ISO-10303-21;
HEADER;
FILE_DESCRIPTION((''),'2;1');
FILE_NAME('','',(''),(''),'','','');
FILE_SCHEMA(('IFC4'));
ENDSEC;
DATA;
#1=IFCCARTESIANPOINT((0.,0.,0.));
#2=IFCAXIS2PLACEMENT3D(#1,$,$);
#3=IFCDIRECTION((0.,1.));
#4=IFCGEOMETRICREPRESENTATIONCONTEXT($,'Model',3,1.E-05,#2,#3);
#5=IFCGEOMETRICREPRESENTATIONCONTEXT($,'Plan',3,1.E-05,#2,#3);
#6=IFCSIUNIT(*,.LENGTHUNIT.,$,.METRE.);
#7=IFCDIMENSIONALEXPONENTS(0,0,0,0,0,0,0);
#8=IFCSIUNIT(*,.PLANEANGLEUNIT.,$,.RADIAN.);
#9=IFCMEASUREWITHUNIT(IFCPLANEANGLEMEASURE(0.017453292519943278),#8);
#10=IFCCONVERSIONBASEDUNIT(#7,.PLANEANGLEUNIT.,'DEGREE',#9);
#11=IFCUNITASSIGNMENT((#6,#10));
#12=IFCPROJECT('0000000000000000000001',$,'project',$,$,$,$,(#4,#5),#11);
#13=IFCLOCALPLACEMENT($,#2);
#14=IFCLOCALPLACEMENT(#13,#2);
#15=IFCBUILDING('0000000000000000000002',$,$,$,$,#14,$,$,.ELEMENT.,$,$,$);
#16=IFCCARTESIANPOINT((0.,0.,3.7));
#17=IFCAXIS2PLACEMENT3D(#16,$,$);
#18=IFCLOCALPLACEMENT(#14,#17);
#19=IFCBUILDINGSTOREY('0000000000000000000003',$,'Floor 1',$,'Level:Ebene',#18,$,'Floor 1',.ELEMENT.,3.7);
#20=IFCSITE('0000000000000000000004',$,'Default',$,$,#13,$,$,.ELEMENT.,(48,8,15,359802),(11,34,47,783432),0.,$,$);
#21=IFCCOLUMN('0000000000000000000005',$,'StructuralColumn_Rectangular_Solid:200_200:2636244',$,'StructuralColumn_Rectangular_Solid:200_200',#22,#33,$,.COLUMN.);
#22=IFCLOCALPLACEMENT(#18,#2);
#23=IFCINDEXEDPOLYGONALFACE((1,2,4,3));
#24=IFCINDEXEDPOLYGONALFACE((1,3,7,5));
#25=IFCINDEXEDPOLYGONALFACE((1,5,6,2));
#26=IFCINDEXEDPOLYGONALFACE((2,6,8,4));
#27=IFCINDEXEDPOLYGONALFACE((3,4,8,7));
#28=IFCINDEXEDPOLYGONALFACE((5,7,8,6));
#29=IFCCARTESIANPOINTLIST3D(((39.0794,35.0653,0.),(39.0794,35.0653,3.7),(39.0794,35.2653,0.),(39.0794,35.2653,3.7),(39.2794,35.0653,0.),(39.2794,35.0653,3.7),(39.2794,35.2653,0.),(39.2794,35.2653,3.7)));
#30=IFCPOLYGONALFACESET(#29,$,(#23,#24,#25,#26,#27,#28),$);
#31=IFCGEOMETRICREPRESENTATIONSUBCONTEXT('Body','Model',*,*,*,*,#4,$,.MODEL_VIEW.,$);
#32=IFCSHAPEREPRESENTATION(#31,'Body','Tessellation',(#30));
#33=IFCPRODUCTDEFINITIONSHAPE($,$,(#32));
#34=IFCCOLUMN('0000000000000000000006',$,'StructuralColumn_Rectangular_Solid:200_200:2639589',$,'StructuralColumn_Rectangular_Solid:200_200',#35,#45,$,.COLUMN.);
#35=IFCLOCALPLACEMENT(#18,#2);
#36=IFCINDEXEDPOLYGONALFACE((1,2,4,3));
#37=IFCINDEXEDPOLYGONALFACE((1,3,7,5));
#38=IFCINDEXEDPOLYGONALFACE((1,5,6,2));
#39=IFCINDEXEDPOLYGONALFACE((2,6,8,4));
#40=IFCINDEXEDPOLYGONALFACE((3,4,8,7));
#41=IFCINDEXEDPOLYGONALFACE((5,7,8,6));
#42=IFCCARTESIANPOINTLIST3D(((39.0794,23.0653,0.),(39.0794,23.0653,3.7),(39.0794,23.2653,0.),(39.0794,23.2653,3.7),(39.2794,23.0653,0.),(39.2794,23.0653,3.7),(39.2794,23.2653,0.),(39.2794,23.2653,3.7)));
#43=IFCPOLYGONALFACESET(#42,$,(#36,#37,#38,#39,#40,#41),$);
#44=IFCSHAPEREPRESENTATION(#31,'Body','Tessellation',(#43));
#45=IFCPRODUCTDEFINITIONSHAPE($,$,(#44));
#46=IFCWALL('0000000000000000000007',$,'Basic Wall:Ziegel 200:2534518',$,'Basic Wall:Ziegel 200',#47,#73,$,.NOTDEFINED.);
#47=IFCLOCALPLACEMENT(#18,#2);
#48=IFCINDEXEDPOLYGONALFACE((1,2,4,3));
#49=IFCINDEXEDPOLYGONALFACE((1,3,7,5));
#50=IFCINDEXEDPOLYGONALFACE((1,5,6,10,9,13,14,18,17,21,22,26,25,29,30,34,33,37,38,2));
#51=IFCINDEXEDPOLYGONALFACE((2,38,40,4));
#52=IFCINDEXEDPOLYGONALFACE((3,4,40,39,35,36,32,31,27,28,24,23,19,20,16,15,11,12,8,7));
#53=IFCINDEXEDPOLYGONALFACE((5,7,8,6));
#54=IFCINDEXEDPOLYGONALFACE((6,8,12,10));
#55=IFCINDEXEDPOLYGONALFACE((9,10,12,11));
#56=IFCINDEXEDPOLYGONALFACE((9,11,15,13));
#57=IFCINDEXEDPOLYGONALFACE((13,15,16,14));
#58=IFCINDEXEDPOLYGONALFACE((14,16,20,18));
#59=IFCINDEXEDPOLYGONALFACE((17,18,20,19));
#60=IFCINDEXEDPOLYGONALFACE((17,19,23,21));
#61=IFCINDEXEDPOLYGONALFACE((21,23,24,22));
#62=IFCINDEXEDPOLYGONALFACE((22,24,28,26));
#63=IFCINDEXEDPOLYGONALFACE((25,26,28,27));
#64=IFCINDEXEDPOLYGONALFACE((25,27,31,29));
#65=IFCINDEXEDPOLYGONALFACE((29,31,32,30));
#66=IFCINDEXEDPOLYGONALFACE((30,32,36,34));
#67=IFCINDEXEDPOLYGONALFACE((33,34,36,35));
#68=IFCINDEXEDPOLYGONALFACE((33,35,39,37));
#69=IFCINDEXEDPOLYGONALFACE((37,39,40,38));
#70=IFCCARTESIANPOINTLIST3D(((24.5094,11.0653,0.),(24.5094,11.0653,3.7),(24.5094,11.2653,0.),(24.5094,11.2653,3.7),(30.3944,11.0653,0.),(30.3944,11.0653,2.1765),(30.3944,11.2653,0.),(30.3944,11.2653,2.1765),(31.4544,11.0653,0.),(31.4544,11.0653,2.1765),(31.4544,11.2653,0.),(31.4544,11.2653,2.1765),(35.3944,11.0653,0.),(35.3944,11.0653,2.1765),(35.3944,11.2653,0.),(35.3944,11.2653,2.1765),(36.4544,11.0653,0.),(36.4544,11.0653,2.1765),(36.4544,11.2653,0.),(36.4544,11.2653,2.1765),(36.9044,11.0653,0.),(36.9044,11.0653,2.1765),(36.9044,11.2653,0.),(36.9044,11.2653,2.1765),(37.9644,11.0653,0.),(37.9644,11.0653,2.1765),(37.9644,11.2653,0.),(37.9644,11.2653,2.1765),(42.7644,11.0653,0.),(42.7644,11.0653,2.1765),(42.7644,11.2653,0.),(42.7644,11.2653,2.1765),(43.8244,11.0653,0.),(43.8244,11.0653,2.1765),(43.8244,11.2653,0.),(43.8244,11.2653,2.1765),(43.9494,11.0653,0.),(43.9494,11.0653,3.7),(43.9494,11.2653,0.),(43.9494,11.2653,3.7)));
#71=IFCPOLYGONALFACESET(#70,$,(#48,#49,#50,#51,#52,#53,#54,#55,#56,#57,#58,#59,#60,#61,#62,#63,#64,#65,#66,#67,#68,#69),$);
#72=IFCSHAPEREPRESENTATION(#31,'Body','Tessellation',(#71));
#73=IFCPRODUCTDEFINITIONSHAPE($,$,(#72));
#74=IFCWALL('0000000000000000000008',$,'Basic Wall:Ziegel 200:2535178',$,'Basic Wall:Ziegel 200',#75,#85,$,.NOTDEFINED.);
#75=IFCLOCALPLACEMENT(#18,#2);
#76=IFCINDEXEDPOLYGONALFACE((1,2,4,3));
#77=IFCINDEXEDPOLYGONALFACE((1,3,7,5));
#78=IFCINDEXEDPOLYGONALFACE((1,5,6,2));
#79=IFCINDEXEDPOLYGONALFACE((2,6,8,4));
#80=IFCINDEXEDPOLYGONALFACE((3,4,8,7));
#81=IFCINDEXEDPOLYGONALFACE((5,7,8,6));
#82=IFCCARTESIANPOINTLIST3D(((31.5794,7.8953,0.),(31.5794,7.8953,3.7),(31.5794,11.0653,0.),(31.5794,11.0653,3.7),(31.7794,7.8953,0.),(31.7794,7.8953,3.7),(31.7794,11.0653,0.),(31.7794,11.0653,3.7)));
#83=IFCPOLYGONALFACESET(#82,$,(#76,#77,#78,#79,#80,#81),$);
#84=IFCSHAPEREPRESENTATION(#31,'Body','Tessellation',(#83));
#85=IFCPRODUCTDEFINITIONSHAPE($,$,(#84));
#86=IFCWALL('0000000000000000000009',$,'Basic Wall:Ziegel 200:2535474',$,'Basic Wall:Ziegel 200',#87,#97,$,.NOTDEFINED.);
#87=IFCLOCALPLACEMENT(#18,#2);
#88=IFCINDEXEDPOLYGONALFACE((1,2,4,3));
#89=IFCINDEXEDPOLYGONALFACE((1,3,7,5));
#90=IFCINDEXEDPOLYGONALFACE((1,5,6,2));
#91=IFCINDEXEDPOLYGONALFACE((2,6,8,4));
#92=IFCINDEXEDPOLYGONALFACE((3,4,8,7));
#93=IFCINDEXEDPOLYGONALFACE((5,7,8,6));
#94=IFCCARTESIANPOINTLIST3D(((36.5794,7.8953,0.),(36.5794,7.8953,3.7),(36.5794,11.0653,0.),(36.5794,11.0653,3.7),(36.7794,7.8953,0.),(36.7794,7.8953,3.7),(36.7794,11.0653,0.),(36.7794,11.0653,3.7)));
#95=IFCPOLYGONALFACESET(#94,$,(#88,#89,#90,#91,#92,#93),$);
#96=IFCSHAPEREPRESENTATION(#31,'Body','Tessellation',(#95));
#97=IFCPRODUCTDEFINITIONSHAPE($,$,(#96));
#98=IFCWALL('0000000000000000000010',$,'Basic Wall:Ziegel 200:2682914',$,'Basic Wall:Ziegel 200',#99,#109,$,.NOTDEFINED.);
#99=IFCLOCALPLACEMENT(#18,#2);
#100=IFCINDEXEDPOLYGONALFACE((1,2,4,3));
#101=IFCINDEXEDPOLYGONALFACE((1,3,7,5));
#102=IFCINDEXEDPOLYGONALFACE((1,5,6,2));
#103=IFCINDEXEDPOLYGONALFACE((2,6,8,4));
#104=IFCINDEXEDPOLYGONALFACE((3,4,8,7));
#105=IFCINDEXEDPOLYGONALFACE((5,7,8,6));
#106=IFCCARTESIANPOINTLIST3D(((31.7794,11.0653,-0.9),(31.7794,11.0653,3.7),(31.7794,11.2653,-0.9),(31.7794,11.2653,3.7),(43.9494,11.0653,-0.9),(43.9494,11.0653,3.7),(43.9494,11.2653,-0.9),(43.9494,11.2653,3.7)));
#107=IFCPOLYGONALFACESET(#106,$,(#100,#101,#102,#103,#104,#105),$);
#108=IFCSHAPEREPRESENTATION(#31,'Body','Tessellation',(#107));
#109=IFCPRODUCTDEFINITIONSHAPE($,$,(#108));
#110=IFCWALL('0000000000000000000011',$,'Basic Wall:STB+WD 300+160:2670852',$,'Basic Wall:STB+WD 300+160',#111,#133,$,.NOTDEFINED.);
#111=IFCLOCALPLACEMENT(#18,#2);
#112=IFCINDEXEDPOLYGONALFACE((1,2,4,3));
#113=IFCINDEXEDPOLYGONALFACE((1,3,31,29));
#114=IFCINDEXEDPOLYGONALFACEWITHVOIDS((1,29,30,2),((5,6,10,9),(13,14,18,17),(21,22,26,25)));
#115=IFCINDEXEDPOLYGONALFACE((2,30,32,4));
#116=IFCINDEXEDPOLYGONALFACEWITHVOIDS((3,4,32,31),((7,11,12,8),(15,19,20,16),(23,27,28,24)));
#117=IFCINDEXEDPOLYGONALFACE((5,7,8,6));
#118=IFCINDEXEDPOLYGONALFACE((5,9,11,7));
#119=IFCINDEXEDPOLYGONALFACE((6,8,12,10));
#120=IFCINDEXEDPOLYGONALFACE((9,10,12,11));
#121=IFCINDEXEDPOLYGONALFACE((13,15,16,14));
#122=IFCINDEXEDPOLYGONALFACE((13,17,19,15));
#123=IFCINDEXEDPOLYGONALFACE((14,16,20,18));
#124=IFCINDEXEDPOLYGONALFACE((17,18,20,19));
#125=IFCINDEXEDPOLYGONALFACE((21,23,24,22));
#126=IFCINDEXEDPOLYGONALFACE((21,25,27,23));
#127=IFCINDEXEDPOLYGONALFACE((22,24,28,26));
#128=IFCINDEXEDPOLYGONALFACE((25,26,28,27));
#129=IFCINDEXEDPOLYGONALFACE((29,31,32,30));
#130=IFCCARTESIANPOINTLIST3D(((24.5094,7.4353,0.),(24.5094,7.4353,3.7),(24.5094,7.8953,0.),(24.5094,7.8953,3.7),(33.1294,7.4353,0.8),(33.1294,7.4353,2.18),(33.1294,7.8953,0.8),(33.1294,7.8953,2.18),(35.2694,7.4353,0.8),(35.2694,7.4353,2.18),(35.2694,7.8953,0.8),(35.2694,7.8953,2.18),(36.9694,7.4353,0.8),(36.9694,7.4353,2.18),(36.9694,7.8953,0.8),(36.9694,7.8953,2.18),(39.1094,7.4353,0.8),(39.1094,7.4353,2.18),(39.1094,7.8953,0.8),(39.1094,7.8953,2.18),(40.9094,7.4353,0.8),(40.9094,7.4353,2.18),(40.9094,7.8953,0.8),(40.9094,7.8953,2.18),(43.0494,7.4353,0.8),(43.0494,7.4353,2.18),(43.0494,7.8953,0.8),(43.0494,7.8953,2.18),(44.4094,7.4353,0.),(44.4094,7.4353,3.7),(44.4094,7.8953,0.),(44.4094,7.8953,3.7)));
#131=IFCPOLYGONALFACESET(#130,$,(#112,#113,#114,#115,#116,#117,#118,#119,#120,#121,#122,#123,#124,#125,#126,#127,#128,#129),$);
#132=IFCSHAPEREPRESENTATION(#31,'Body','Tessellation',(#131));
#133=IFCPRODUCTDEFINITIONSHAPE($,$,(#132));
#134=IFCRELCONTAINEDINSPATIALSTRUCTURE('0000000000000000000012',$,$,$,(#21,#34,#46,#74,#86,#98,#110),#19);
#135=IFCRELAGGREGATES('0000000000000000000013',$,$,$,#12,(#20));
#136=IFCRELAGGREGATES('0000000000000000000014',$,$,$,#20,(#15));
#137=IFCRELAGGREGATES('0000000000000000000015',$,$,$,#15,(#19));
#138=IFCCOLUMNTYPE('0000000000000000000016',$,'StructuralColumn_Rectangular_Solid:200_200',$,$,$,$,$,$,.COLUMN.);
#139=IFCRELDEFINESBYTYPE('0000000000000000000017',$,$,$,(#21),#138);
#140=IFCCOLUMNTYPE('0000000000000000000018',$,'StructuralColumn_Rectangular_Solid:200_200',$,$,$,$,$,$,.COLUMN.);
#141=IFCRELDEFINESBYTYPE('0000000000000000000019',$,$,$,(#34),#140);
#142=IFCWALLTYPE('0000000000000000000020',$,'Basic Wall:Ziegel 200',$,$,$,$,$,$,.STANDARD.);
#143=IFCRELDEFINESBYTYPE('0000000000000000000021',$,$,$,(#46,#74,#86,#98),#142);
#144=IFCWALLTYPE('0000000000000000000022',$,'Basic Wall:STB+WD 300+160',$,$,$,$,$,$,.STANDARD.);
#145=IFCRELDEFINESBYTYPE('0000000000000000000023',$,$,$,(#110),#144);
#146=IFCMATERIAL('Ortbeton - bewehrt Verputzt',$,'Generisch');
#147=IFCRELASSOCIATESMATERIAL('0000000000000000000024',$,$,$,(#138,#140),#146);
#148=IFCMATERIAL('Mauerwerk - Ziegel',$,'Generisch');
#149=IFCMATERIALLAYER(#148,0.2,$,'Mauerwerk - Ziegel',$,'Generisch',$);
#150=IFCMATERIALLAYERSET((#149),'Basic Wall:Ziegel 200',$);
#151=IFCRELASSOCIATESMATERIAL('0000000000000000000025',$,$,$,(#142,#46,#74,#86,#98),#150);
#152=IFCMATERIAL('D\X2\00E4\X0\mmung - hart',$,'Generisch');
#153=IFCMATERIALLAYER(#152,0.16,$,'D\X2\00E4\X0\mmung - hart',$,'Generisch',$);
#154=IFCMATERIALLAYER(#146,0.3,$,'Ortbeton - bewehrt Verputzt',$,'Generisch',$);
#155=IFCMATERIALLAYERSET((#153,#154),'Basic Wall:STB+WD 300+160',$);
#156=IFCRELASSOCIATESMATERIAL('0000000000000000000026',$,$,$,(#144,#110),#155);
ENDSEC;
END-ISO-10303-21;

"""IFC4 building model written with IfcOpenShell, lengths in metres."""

from ifc_helpers import new_model, entity, si_unit, converted_unit, direction, frame, frame_2d, origin, place, context, subcontext, project, spatial, rectangle, extrude, source, transform, mapped, material, layer, layer_set, layer_usage, material_profile, profile_set, type_object, type_shapes, element, save


model = new_model("IFC4")

# Units and contexts
model_context = context("Model", 3, precision=1e-05, world=origin(), true_north=direction((0.0, 1.0)))
plan_context = context("Plan", 3, precision=1e-05, world=origin(), true_north=direction((0.0, 1.0)))
body_context = subcontext(model_context, "Body", "Model", "MODEL_VIEW")
ifc_project = project(units=[si_unit("LENGTHUNIT", "METRE"), converted_unit("PLANEANGLEUNIT", "DEGREE", entity("IfcPlaneAngleMeasure", 0.017453292519943278), si_unit("PLANEANGLEUNIT", "RADIAN"), dimensions=[0, 0, 0, 0, 0, 0, 0])], contexts=[model_context, plan_context])

# Site, building, storey
site_placement = place(None, origin())
site = spatial("IfcSite", under=ifc_project, at=site_placement, Name="Default", CompositionType="ELEMENT", RefLatitude=(48, 8, 15, 359802), RefLongitude=(11, 34, 47, 783432), RefElevation=0.0)
building_placement = place(site_placement, origin())
building = spatial("IfcBuilding", under=site, at=building_placement, CompositionType="ELEMENT")
storey_placement = place(building_placement, frame((0.0, 0.0, 3.7)))
storey = spatial("IfcBuildingStorey", under=building, at=storey_placement, Name="Floor 1", ObjectType="Level:Ebene", LongName="Floor 1", CompositionType="ELEMENT", Elevation=3.7)

# Columns
ifc_material_1 = material(Name="Ortbeton - bewehrt Verputzt", Category="Generisch")
ifc_material_profile = material_profile(ifc_material_1, rectangle(XDim=0.2, YDim=0.2, at=frame_2d((0.0, 0.0), x_axis=(1.0, 0.0))), Name="200_200")
ifc_profile_set = profile_set([ifc_material_profile], Name="200_200")
column_type_1 = type_object("IfcColumnType", Name="StructuralColumn_Rectangular_Solid:200_200", PredefinedType="COLUMN", material=ifc_profile_set)
shared_shape_1 = source(origin(), body_context, "Body", "SweptSolid", [
    extrude(rectangle(XDim=0.2, YDim=0.2, at=frame_2d((0.0, 0.0), x_axis=(1.0, 0.0))), frame((39.1794, 35.1653, 3.7), z_axis=(0.0, 0.0, 1.0), x_axis=(-1.0, 0.0, 0.0)), (0.0, 0.0, 1.0), 3.7),
])
type_shapes(column_type_1, [shared_shape_1])
column_1_placement = place(storey_placement, frame((0.0, 0.0, -3.7)))
element("IfcColumn", 1, at=column_1_placement, inside=storey, type_object=column_type_1, Name="StructuralColumn_Rectangular_Solid:200_200:2636244", ObjectType="StructuralColumn_Rectangular_Solid:200_200", PredefinedType="COLUMN", context=body_context, shape_type="MappedRepresentation", body=[
    mapped(shared_shape_1, transform((0.0, 0.0, 0.0), scale=1.0)),
])
column_type_2 = type_object("IfcColumnType", Name="StructuralColumn_Rectangular_Solid:200_200", PredefinedType="COLUMN", material=ifc_profile_set)
shared_shape_2 = source(origin(), body_context, "Body", "SweptSolid", [
    extrude(rectangle(XDim=0.2, YDim=0.2, at=frame_2d((0.0, 0.0), x_axis=(1.0, 0.0))), frame((39.1794, 23.1653, 3.7), z_axis=(0.0, 0.0, 1.0), x_axis=(-1.0, 0.0, 0.0)), (0.0, 0.0, 1.0), 3.7),
])
type_shapes(column_type_2, [shared_shape_2])
column_2_placement = place(storey_placement, frame((0.0, 0.0, -3.7)))
element("IfcColumn", 2, at=column_2_placement, inside=storey, type_object=column_type_2, Name="StructuralColumn_Rectangular_Solid:200_200:2639589", ObjectType="StructuralColumn_Rectangular_Solid:200_200", PredefinedType="COLUMN", context=body_context, shape_type="MappedRepresentation", body=[
    mapped(shared_shape_2, transform((0.0, 0.0, 0.0), scale=1.0)),
])

# Wall, openings
ifc_material_2 = material(Name="Mauerwerk - Ziegel", Category="Generisch")
ifc_layer_1 = layer(ifc_material_2, 0.2, Name="Mauerwerk - Ziegel", Category="Generisch")
ifc_layer_set_1 = layer_set([ifc_layer_1], Name="Basic Wall:Ziegel 200")
ifc_layer_usage_1 = layer_usage(ifc_layer_set_1, "AXIS2", "NEGATIVE", 0.1)
wall_type_1 = type_object("IfcWallType", Name="Basic Wall:Ziegel 200", PredefinedType="STANDARD", material=ifc_layer_set_1)
wall_1_placement = place(storey_placement, frame((43.9494, 11.1653, 0.0), z_axis=(0.0, 0.0, 1.0), x_axis=(-1.0, 0.0, 0.0)))
wall_1 = element("IfcWall", 3, at=wall_1_placement, inside=storey, type_object=wall_type_1, material=ifc_layer_usage_1, Name="Basic Wall:Ziegel 200:2534518", ObjectType="Basic Wall:Ziegel 200", PredefinedType="NOTDEFINED", context=body_context, shape_type="SweptSolid", body=[
    extrude(rectangle(XDim=19.44, YDim=0.2, at=frame_2d((9.72, 0.0), x_axis=(1.0, 0.0))), origin(), (0.0, 0.0, 1.0), 3.7),
])
opening_1_placement = place(wall_1_placement, frame((13.555, 0.1, 0.0)))
element("IfcOpeningElement", 4, at=opening_1_placement, cuts=wall_1, PredefinedType="OPENING", context=body_context, shape_type="SweptSolid", body=[
    extrude(rectangle(XDim=2.1765, YDim=1.06, at=frame_2d((1.0882, 0.53), x_axis=(1.0, 0.0))), frame((0.0, 0.0, 0.0), z_axis=(0.0, -1.0, 0.0), x_axis=(0.0, 0.0, 1.0)), (0.0, 0.0, 1.0), 0.2),
])
opening_2_placement = place(wall_1_placement, frame((8.555, 0.1, 0.0)))
element("IfcOpeningElement", 5, at=opening_2_placement, cuts=wall_1, PredefinedType="OPENING", context=body_context, shape_type="SweptSolid", body=[
    extrude(rectangle(XDim=2.1765, YDim=1.06, at=frame_2d((1.0882, 0.53), x_axis=(1.0, 0.0))), frame((0.0, 0.0, 0.0), z_axis=(0.0, -1.0, 0.0), x_axis=(0.0, 0.0, 1.0)), (0.0, 0.0, 1.0), 0.2),
])
opening_3_placement = place(wall_1_placement, frame((7.045, 0.1, 0.0)))
element("IfcOpeningElement", 6, at=opening_3_placement, cuts=wall_1, PredefinedType="OPENING", context=body_context, shape_type="SweptSolid", body=[
    extrude(rectangle(XDim=2.1765, YDim=1.06, at=frame_2d((1.0882, 0.53), x_axis=(1.0, 0.0))), frame((0.0, 0.0, 0.0), z_axis=(0.0, -1.0, 0.0), x_axis=(0.0, 0.0, 1.0)), (0.0, 0.0, 1.0), 0.2),
])
opening_4_placement = place(wall_1_placement, frame((1.185, 0.1, 0.0)))
element("IfcOpeningElement", 7, at=opening_4_placement, cuts=wall_1, PredefinedType="OPENING", context=body_context, shape_type="SweptSolid", body=[
    extrude(rectangle(XDim=2.1765, YDim=1.06, at=frame_2d((1.0882, 0.53), x_axis=(1.0, 0.0))), frame((0.0, 0.0, 0.0), z_axis=(0.0, -1.0, 0.0), x_axis=(0.0, 0.0, 1.0)), (0.0, 0.0, 1.0), 0.2),
])

# Walls
wall_2_placement = place(storey_placement, frame((31.6794, 11.0653, 0.0), z_axis=(0.0, 0.0, 1.0), x_axis=(0.0, -1.0, 0.0)))
element("IfcWall", 8, at=wall_2_placement, inside=storey, type_object=wall_type_1, material=ifc_layer_usage_1, Name="Basic Wall:Ziegel 200:2535178", ObjectType="Basic Wall:Ziegel 200", PredefinedType="NOTDEFINED", context=body_context, shape_type="SweptSolid", body=[
    extrude(rectangle(XDim=3.17, YDim=0.2, at=frame_2d((1.585, 0.0), x_axis=(-1.0, 0.0))), origin(), (0.0, 0.0, 1.0), 3.7),
])
wall_3_placement = place(storey_placement, frame((36.6794, 11.0653, 0.0), z_axis=(0.0, 0.0, 1.0), x_axis=(0.0, -1.0, 0.0)))
element("IfcWall", 9, at=wall_3_placement, inside=storey, type_object=wall_type_1, material=ifc_layer_usage_1, Name="Basic Wall:Ziegel 200:2535474", ObjectType="Basic Wall:Ziegel 200", PredefinedType="NOTDEFINED", context=body_context, shape_type="SweptSolid", body=[
    extrude(rectangle(XDim=3.17, YDim=0.2, at=frame_2d((1.585, 0.0), x_axis=(-1.0, 0.0))), origin(), (0.0, 0.0, 1.0), 3.7),
])
wall_4_placement = place(storey_placement, frame((43.9494, 11.1653, -0.9), z_axis=(0.0, 0.0, 1.0), x_axis=(-1.0, 0.0, 0.0)))
element("IfcWall", 10, at=wall_4_placement, inside=storey, type_object=wall_type_1, material=ifc_layer_usage_1, Name="Basic Wall:Ziegel 200:2682914", ObjectType="Basic Wall:Ziegel 200", PredefinedType="NOTDEFINED", context=body_context, shape_type="SweptSolid", body=[
    extrude(rectangle(XDim=12.17, YDim=0.2, at=frame_2d((6.085, 0.0), x_axis=(-1.0, 0.0))), origin(), (0.0, 0.0, 1.0), 4.6),
])

# Wall, openings
ifc_material_3 = material(Name="Dämmung - hart", Category="Generisch")
ifc_layer_2 = layer(ifc_material_3, 0.16, Name="Dämmung - hart", Category="Generisch")
ifc_layer_3 = layer(ifc_material_1, 0.3, Name="Ortbeton - bewehrt Verputzt", Category="Generisch")
ifc_layer_set_2 = layer_set([ifc_layer_2, ifc_layer_3], Name="Basic Wall:STB+WD 300+160")
ifc_layer_usage_2 = layer_usage(ifc_layer_set_2, "AXIS2", "POSITIVE", -0.23)
wall_type_2 = type_object("IfcWallType", Name="Basic Wall:STB+WD 300+160", PredefinedType="STANDARD", material=ifc_layer_set_2)
wall_5_placement = place(storey_placement, frame((24.5094, 7.6653, 0.0)))
wall_5 = element("IfcWall", 11, at=wall_5_placement, inside=storey, type_object=wall_type_2, material=ifc_layer_usage_2, Name="Basic Wall:STB+WD 300+160:2670852", ObjectType="Basic Wall:STB+WD 300+160", PredefinedType="NOTDEFINED", context=body_context, shape_type="SweptSolid", body=[
    extrude(rectangle(XDim=19.9, YDim=0.46, at=frame_2d((9.95, 0.0), x_axis=(-1.0, 0.0))), origin(), (0.0, 0.0, 1.0), 3.7),
])
opening_5_placement = place(wall_5_placement, frame((-24.5094, -7.6653, 0.8)))
element("IfcOpeningElement", 12, at=opening_5_placement, cuts=wall_5, PredefinedType="OPENING", context=body_context, shape_type="SweptSolid", body=[
    extrude(rectangle(XDim=1.38, YDim=2.14, at=frame_2d((0.0, 0.0), x_axis=(0.0, 1.0))), frame((41.9794, 6.3713, 0.69), z_axis=(0.0, 1.0, 0.0), x_axis=(-1.0, 0.0, 0.0)), (0.0, 0.0, 1.0), 3.048),
])
opening_6_placement = place(wall_5_placement, frame((-24.5094, -7.6653, 0.8)))
element("IfcOpeningElement", 13, at=opening_6_placement, cuts=wall_5, PredefinedType="OPENING", context=body_context, shape_type="SweptSolid", body=[
    extrude(rectangle(XDim=1.38, YDim=2.14, at=frame_2d((0.0, 0.0), x_axis=(0.0, 1.0))), frame((38.0394, 6.3713, 0.69), z_axis=(0.0, 1.0, 0.0), x_axis=(-1.0, 0.0, 0.0)), (0.0, 0.0, 1.0), 3.048),
])
opening_7_placement = place(wall_5_placement, frame((-24.5094, -7.6653, 0.8)))
element("IfcOpeningElement", 14, at=opening_7_placement, cuts=wall_5, PredefinedType="OPENING", context=body_context, shape_type="SweptSolid", body=[
    extrude(rectangle(XDim=1.38, YDim=2.14, at=frame_2d((0.0, 0.0), x_axis=(0.0, 1.0))), frame((34.1994, 6.3713, 0.69), z_axis=(0.0, 1.0, 0.0), x_axis=(-1.0, 0.0, 0.0)), (0.0, 0.0, 1.0), 3.048),
])

save(model, "model.ifc")
